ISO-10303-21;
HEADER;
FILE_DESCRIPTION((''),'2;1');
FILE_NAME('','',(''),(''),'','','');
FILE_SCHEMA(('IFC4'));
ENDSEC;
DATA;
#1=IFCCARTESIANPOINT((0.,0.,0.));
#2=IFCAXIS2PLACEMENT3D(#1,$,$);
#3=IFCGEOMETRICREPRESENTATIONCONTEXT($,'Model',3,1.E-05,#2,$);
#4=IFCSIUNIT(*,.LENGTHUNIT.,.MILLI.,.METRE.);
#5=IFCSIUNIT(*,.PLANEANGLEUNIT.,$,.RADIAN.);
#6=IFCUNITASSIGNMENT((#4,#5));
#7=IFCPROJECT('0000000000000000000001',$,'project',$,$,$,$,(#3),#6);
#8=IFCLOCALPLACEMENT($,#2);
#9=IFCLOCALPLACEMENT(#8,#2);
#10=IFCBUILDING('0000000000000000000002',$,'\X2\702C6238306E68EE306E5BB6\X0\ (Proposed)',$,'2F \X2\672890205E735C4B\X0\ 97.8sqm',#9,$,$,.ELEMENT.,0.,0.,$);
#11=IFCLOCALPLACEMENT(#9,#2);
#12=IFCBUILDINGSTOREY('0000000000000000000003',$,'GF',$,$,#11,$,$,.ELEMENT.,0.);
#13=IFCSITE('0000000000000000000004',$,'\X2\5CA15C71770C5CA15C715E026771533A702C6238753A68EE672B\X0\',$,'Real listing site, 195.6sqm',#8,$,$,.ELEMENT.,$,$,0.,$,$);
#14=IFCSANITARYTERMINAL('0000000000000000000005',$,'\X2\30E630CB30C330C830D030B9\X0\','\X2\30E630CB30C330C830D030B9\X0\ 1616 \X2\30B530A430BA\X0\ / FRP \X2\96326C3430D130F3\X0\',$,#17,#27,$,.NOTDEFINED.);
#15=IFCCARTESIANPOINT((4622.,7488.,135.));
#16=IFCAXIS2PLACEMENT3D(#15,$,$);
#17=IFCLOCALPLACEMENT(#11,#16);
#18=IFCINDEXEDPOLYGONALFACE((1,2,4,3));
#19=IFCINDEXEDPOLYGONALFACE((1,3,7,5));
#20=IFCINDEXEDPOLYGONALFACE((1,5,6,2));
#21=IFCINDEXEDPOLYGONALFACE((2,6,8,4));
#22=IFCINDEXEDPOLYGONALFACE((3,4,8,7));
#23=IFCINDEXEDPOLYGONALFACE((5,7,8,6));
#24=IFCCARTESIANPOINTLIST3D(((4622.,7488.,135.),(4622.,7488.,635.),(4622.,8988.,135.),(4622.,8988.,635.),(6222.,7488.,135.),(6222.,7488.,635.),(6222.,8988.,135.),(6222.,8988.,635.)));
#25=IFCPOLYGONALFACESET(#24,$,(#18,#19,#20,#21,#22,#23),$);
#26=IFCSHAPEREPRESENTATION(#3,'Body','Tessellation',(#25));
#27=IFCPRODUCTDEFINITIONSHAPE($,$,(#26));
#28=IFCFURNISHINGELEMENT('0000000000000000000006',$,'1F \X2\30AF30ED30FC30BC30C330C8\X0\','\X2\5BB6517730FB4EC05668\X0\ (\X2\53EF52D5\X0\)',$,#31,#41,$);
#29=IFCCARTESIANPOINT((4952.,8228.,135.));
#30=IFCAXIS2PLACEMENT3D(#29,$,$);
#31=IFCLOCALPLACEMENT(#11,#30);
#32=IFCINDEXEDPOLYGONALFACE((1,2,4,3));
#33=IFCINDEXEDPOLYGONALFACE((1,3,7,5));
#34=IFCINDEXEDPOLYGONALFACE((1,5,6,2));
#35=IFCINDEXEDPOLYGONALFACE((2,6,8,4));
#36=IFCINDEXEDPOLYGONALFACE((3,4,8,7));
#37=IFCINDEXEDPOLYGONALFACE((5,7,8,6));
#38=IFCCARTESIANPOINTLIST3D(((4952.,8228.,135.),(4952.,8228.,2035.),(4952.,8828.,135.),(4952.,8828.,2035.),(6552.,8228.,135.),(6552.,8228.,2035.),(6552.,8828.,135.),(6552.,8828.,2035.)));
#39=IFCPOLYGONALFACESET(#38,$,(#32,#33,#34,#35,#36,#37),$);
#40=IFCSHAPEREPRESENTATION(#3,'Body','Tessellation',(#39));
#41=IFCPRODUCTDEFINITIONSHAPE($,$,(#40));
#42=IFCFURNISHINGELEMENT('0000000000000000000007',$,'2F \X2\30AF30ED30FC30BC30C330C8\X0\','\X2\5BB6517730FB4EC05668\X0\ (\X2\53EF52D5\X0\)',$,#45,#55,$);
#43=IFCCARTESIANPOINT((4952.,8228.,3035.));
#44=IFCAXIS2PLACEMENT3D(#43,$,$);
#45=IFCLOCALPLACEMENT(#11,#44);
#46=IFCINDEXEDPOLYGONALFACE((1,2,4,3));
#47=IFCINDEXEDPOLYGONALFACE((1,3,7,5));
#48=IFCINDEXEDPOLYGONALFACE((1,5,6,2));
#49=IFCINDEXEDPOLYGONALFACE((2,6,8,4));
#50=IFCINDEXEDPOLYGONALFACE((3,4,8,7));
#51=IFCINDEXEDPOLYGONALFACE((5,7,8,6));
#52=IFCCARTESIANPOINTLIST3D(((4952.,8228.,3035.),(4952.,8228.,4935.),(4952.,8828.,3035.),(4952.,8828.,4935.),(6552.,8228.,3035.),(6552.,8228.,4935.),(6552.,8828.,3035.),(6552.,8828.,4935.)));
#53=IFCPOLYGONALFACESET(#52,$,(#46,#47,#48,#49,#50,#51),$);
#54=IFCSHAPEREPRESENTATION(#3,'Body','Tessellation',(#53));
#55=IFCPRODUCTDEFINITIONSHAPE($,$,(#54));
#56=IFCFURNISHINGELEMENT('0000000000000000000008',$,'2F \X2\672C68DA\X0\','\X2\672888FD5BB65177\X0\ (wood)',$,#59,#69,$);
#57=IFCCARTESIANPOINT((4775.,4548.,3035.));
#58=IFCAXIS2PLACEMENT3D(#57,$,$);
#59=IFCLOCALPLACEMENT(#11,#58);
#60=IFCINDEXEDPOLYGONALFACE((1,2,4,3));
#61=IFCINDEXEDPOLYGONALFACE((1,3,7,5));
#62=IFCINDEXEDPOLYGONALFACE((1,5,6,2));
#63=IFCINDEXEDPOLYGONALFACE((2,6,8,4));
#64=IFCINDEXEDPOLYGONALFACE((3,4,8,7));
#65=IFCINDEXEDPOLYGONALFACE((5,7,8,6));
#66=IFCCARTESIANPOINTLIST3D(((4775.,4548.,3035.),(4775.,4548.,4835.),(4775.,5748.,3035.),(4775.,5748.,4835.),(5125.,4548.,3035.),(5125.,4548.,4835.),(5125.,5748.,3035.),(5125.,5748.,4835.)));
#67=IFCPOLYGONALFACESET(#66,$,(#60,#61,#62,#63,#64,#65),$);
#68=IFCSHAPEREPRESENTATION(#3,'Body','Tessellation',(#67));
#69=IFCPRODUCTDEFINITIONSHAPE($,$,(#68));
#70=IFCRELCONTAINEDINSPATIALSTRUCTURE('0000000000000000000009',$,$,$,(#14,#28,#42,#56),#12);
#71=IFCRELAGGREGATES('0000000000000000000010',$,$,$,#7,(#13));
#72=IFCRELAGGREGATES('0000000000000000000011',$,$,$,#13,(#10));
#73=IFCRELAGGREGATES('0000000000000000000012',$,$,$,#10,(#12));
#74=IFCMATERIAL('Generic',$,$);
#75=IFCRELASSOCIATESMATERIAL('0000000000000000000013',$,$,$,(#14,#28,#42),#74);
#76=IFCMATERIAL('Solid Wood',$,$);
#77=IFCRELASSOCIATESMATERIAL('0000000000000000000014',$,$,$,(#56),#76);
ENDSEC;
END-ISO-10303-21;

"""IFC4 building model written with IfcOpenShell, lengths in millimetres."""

from ifc_helpers import new_model, si_unit, frame, frame_2d, origin, place, context, project, spatial, rectangle, extrude, material, element, save


model = new_model("IFC4")

# Units and contexts
model_context = context("Model", 3, precision=1e-05, world=origin())
ifc_project = project(units=[si_unit("LENGTHUNIT", "METRE", prefix="MILLI"), si_unit("PLANEANGLEUNIT", "RADIAN")], contexts=[model_context])

# Site, building, storey
site_placement = place(None, origin())
site = spatial("IfcSite", under=ifc_project, at=site_placement, Name="岡山県岡山市東区瀬戸町森末", ObjectType="Real listing site, 195.6sqm", CompositionType="ELEMENT", RefElevation=0.0)
building_placement = place(site_placement, origin())
building = spatial("IfcBuilding", under=site, at=building_placement, Name="瀬戸の森の家 (Proposed)", ObjectType="2F 木造平屋 97.8sqm", CompositionType="ELEMENT", ElevationOfRefHeight=0.0, ElevationOfTerrain=0.0)
storey_placement = place(building_placement, origin())
storey = spatial("IfcBuildingStorey", under=building, at=storey_placement, Name="GF", CompositionType="ELEMENT", Elevation=0.0)

# Shared definitions
ifc_material_1 = material(Name="Solid Wood")

# Shared definitions
ifc_material_2 = material(Name="Generic")

# Sanitary terminal
sanitary_terminal_placement = place(storey_placement, frame((4622.0, 7488.0, 135.0)))
element("IfcSanitaryTerminal", 1, at=sanitary_terminal_placement, inside=storey, material=ifc_material_2, Name="ユニットバス", Description="ユニットバス 1616 サイズ / FRP 防水パン", PredefinedType="NOTDEFINED", context=model_context, shape_type="SweptSolid", body=[
    extrude(rectangle(XDim=1600.0, YDim=1500.0, at=frame_2d((800.0, 750.0))), frame((4622.0, 7488.0, 135.0)), (0.0, 0.0, 1.0), 500.0),
])

# Furnishing elements
furnishing_1_placement = place(storey_placement, frame((4952.0, 8228.0, 135.0)))
element("IfcFurnishingElement", 2, at=furnishing_1_placement, inside=storey, material=ifc_material_2, Name="1F クローゼット", Description="家具・什器 (可動)", context=model_context, shape_type="SweptSolid", body=[
    extrude(rectangle(XDim=1600.0, YDim=600.0, at=frame_2d((800.0, 300.0))), frame((4952.0, 8228.0, 135.0)), (0.0, 0.0, 1.0), 1900.0),
])
furnishing_2_placement = place(storey_placement, frame((4952.0, 8228.0, 3035.0)))
element("IfcFurnishingElement", 3, at=furnishing_2_placement, inside=storey, material=ifc_material_2, Name="2F クローゼット", Description="家具・什器 (可動)", context=model_context, shape_type="SweptSolid", body=[
    extrude(rectangle(XDim=1600.0, YDim=600.0, at=frame_2d((800.0, 300.0))), frame((4952.0, 8228.0, 3035.0)), (0.0, 0.0, 1.0), 1900.0),
])
furnishing_3_placement = place(storey_placement, frame((4775.0, 4548.0, 3035.0)))
element("IfcFurnishingElement", 4, at=furnishing_3_placement, inside=storey, material=ifc_material_1, Name="2F 本棚", Description="木製家具 (wood)", context=model_context, shape_type="SweptSolid", body=[
    extrude(rectangle(XDim=350.0, YDim=1200.0, at=frame_2d((175.0, 600.0))), frame((4775.0, 4548.0, 3035.0)), (0.0, 0.0, 1.0), 1800.0),
])

save(model, "model.ifc")
